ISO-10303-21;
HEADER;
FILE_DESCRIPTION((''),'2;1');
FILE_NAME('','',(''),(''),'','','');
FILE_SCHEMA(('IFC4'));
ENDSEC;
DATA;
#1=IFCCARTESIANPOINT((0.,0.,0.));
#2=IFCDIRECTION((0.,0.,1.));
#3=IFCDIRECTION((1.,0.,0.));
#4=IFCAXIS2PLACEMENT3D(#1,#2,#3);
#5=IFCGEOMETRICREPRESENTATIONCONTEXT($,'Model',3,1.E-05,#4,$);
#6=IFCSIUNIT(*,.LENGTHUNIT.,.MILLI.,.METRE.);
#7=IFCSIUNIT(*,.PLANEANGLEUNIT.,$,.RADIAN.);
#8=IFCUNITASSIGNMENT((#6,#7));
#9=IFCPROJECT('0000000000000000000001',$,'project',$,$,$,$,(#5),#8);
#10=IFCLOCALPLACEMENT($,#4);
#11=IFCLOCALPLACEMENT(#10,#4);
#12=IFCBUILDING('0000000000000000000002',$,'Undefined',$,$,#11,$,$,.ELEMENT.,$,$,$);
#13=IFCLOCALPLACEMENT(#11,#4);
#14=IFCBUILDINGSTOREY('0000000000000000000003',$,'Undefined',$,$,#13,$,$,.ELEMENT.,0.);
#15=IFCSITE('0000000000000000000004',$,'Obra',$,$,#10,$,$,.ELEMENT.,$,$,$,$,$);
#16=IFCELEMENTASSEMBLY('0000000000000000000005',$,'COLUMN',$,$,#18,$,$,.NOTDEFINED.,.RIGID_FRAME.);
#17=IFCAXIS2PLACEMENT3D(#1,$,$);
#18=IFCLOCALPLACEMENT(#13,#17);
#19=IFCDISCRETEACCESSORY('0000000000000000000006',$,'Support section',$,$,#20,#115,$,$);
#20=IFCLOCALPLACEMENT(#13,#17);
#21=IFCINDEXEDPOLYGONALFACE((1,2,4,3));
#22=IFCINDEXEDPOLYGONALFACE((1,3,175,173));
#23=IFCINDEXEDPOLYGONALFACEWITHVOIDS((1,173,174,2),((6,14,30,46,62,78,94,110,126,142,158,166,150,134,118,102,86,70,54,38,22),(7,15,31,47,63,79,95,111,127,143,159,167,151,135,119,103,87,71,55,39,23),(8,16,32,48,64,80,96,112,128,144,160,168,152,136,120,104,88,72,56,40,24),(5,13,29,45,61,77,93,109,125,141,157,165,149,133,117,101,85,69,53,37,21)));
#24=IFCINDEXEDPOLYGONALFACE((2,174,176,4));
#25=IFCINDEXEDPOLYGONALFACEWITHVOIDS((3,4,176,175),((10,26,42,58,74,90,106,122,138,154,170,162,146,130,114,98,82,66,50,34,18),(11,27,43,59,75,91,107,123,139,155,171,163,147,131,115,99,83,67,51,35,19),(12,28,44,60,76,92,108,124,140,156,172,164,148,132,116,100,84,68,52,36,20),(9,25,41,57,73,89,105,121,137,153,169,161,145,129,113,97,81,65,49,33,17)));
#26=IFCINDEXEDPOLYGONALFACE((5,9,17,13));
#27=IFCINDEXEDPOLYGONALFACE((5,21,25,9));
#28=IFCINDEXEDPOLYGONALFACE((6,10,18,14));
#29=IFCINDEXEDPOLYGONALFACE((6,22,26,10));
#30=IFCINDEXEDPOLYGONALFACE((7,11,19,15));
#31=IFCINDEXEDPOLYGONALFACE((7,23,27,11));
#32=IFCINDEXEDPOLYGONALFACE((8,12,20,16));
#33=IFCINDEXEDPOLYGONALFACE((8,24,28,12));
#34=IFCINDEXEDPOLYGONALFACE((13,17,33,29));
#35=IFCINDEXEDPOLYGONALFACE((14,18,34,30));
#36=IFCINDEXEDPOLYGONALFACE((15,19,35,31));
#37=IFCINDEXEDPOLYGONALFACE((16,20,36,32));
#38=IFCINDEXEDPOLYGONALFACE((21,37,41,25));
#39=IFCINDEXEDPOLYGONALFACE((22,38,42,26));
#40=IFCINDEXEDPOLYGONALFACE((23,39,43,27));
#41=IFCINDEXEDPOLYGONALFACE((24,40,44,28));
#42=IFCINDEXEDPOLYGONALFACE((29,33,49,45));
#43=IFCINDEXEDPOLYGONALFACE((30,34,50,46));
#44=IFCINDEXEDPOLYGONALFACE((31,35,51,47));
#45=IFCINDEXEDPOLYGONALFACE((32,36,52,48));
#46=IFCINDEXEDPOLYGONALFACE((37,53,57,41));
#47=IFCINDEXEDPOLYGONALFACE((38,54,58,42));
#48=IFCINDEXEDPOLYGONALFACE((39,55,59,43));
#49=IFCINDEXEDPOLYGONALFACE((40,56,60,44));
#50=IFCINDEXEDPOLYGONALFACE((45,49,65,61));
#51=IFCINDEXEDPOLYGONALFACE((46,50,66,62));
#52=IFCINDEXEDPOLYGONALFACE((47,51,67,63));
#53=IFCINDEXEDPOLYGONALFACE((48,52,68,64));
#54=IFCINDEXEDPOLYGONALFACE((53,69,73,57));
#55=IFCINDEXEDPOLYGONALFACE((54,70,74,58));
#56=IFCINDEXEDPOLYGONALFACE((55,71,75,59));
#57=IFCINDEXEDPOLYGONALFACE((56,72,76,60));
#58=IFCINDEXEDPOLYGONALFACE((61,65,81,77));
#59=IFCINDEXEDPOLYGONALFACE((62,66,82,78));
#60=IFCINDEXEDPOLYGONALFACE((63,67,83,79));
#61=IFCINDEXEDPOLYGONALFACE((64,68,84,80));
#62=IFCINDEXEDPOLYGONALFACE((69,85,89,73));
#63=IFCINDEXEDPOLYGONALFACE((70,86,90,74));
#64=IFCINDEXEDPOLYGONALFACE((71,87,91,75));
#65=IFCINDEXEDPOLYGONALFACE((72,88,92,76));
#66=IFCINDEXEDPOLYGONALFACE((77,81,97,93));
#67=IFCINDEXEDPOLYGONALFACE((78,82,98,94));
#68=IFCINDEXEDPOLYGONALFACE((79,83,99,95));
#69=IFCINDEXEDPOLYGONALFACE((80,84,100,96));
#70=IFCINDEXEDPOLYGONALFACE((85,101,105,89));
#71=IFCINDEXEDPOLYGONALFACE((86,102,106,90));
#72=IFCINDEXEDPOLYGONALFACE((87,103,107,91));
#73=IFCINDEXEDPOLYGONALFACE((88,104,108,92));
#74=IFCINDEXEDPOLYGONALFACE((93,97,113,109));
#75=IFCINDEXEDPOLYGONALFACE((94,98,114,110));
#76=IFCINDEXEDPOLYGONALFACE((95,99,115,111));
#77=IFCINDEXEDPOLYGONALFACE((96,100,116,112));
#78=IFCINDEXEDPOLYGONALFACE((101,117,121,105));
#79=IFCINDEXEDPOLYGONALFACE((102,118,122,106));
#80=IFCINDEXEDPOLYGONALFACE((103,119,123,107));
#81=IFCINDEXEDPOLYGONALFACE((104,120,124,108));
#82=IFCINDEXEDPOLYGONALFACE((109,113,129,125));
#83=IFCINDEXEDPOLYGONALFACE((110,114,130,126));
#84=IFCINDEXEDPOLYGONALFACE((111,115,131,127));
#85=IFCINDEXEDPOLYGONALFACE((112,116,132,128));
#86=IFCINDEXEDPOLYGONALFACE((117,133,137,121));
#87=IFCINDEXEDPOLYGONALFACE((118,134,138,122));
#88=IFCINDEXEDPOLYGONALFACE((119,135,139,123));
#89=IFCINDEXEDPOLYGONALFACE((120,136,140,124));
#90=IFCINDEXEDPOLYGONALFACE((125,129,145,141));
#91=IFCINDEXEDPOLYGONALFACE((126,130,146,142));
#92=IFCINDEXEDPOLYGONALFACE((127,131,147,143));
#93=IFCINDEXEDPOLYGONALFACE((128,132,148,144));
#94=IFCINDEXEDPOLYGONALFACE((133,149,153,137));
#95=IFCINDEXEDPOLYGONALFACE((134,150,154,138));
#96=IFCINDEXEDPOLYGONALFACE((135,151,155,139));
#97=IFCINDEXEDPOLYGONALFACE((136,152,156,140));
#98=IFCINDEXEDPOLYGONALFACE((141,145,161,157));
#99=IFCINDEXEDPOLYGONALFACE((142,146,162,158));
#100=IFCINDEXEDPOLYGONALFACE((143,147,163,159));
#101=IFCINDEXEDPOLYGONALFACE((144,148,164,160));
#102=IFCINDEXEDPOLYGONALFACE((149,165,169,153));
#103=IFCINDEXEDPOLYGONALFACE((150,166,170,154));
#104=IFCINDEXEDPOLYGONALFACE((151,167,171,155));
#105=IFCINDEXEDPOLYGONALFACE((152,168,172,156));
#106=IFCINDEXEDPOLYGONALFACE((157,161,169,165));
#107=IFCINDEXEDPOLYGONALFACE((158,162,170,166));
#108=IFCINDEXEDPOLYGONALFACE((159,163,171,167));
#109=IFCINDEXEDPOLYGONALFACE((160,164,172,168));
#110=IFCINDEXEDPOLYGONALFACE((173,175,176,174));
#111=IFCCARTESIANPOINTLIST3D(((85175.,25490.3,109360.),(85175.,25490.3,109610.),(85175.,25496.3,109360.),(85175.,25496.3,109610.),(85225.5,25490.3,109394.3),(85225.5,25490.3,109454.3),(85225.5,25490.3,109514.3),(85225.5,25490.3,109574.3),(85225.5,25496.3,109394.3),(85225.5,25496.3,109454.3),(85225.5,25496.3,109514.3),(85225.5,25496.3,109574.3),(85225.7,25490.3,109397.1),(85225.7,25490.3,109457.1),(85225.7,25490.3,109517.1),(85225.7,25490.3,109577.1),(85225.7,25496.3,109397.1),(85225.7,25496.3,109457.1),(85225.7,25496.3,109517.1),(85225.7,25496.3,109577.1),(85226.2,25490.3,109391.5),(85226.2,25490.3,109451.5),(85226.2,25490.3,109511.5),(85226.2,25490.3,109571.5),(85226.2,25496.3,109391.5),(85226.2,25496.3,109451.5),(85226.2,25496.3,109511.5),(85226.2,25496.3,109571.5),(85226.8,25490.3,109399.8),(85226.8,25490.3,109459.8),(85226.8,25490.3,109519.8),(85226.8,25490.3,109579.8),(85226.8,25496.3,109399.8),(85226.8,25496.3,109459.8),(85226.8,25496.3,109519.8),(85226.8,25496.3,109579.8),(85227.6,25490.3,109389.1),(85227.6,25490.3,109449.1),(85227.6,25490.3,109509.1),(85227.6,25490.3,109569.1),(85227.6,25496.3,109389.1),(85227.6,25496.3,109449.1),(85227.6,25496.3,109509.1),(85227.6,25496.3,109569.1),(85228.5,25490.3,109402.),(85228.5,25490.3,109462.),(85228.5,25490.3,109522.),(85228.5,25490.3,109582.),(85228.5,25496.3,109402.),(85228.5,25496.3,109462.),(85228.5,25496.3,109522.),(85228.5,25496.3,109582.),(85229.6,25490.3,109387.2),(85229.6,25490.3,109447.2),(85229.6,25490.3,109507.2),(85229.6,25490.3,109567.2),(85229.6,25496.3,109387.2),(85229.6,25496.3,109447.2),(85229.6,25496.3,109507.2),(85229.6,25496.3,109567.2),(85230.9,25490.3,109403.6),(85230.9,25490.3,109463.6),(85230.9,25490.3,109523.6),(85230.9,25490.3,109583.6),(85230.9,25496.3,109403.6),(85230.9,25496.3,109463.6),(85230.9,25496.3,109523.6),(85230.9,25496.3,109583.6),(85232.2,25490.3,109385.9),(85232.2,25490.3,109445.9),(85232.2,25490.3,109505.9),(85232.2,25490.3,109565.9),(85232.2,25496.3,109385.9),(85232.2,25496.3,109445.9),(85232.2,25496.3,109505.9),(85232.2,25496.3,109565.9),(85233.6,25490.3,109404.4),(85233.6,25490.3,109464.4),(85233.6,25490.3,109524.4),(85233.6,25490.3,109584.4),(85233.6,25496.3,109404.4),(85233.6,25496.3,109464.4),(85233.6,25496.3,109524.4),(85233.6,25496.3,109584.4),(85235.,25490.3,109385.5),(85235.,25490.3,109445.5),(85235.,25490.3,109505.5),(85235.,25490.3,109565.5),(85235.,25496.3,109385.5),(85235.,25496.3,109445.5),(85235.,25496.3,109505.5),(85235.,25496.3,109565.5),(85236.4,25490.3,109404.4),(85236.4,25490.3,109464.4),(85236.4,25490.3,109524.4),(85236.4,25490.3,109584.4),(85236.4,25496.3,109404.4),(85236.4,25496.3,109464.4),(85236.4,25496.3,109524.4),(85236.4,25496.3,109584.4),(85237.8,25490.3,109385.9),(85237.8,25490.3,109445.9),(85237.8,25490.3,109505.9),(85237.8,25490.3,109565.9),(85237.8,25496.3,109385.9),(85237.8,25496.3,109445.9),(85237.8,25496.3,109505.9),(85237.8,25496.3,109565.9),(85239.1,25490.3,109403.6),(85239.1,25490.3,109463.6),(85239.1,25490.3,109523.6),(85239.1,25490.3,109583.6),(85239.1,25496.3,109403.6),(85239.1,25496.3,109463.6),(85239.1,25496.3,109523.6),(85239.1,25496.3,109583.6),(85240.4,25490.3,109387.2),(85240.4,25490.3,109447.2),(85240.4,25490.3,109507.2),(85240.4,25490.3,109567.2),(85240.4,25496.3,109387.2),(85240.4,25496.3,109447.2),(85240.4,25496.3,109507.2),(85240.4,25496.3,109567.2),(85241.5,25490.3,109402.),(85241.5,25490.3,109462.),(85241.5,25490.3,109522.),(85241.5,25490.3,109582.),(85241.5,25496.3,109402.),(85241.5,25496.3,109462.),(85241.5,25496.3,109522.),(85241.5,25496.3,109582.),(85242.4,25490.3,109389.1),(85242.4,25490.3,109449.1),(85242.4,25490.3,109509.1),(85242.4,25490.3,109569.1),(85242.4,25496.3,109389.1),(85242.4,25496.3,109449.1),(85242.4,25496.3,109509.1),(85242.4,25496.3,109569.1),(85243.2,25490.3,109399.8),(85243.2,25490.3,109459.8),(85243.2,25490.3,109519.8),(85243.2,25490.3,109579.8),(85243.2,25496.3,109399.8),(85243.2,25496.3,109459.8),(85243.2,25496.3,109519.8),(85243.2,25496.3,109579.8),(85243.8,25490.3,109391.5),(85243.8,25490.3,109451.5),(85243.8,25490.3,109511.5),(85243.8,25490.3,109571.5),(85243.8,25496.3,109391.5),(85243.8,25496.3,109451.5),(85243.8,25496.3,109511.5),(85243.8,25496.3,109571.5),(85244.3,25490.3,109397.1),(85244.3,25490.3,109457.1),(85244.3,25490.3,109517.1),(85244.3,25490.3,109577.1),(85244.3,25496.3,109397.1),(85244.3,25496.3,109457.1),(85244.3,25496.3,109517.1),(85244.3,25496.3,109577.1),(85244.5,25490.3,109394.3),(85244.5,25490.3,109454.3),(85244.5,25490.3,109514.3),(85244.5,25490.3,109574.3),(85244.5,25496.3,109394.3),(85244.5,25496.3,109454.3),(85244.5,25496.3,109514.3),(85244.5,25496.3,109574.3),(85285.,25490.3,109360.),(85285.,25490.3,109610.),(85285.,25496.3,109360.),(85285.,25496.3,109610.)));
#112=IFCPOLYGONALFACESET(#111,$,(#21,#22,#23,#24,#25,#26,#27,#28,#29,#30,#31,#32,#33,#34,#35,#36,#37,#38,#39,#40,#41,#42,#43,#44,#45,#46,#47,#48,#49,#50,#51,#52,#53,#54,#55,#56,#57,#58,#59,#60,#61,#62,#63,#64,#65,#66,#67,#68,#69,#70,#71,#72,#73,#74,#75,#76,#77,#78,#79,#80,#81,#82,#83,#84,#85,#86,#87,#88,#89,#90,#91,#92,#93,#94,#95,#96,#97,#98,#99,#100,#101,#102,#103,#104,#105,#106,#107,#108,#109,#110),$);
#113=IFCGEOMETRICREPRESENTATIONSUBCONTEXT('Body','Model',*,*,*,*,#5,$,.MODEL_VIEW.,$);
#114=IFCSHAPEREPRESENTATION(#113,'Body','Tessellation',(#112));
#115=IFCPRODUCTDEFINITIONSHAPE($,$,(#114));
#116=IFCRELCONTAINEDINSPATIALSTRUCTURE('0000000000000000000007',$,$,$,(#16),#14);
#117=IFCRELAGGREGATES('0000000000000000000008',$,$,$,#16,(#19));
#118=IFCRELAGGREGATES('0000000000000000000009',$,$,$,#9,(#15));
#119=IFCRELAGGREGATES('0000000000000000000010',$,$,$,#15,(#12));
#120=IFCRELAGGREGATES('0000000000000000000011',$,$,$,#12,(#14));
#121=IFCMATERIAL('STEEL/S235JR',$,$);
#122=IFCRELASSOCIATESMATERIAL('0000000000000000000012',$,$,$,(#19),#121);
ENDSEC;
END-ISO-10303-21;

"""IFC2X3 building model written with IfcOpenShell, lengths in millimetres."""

from ifc_helpers import new_model, si_unit, frame, origin_with_axes, origin_2d_with_axis, place, context, subcontext, project, spatial, rectangle, circle, extrude, source, transform, mapped, material, element, aggregate, save


model = new_model("IFC2X3")

# Units and contexts
model_context = context("Model", 3, precision=1e-05, world=origin_with_axes())
body_context = subcontext(model_context, "Body", "Model", "MODEL_VIEW")
ifc_project = project(units=[si_unit("LENGTHUNIT", "METRE", prefix="MILLI"), si_unit("PLANEANGLEUNIT", "RADIAN")], contexts=[model_context])

# Site, building, storey
site_placement = place(None, origin_with_axes())
site = spatial("IfcSite", under=ifc_project, at=site_placement, Name="Obra", CompositionType="ELEMENT")
building_placement = place(site_placement, origin_with_axes())
building = spatial("IfcBuilding", under=site, at=building_placement, Name="Undefined", CompositionType="ELEMENT")
storey_placement = place(building_placement, origin_with_axes())
storey = spatial("IfcBuildingStorey", under=building, at=storey_placement, Name="Undefined", CompositionType="ELEMENT", Elevation=0.0)

# Element assembly
ifc_material_1 = material(Name="STEEL/S235JR")
assembly_1_placement = place(storey_placement, origin_with_axes())
assembly_1 = element("IfcElementAssembly", 1, at=assembly_1_placement, inside=storey, Name="COLUMN", AssemblyPlace="NOTDEFINED", PredefinedType="RIGID_FRAME")

# Discrete accessory, opening
shared_shape_1 = source(origin_with_axes(), body_context, "Body", "SweptSolid", [
    extrude(circle(Radius=9.5, at=origin_2d_with_axis()), frame((0.0, -9.8, 0.0), z_axis=(0.0, 1.0, 0.0), x_axis=(1.0, 0.0, 0.0)), (0.0, 0.0, 1.0), 6.2),
])
discrete_accessory_1_placement = place(assembly_1_placement, frame((85230.0, 25493.3, 109360.0), z_axis=(0.0, 0.0, 1.0), x_axis=(-1.0, 0.0, 0.0)))
discrete_accessory_1 = element("IfcDiscreteAccessory", 2, at=discrete_accessory_1_placement, material=ifc_material_1, Name="Support section", context=body_context, shape_type="SweptSolid", body=[
    extrude(rectangle(XDim=6.0, YDim=110.0, at=origin_2d_with_axis()), frame((0.0, 0.0, 250.0), z_axis=(0.0, 0.0, -1.0), x_axis=(0.0, 1.0, 0.0)), (0.0, 0.0, 1.0), 250.0),
])
opening_1_placement = place(assembly_1_placement, frame((85185.0, 25500.0, 109650.0), z_axis=(1.0, 0.0, 0.0), x_axis=(0.0, 0.0, -1.0)))
element("IfcOpeningElement", 3, at=opening_1_placement, cuts=discrete_accessory_1, ObjectType="Opening", context=body_context, shape_type="MappedRepresentation", body=[
    mapped(shared_shape_1, transform((75.0, 0.0, 50.0))),
    mapped(shared_shape_1, transform((135.0, 0.0, 50.0))),
    mapped(shared_shape_1, transform((195.0, 0.0, 50.0))),
    mapped(shared_shape_1, transform((255.0, 0.0, 50.0))),
])
aggregate(assembly_1, [discrete_accessory_1])

save(model, "model.ifc")
